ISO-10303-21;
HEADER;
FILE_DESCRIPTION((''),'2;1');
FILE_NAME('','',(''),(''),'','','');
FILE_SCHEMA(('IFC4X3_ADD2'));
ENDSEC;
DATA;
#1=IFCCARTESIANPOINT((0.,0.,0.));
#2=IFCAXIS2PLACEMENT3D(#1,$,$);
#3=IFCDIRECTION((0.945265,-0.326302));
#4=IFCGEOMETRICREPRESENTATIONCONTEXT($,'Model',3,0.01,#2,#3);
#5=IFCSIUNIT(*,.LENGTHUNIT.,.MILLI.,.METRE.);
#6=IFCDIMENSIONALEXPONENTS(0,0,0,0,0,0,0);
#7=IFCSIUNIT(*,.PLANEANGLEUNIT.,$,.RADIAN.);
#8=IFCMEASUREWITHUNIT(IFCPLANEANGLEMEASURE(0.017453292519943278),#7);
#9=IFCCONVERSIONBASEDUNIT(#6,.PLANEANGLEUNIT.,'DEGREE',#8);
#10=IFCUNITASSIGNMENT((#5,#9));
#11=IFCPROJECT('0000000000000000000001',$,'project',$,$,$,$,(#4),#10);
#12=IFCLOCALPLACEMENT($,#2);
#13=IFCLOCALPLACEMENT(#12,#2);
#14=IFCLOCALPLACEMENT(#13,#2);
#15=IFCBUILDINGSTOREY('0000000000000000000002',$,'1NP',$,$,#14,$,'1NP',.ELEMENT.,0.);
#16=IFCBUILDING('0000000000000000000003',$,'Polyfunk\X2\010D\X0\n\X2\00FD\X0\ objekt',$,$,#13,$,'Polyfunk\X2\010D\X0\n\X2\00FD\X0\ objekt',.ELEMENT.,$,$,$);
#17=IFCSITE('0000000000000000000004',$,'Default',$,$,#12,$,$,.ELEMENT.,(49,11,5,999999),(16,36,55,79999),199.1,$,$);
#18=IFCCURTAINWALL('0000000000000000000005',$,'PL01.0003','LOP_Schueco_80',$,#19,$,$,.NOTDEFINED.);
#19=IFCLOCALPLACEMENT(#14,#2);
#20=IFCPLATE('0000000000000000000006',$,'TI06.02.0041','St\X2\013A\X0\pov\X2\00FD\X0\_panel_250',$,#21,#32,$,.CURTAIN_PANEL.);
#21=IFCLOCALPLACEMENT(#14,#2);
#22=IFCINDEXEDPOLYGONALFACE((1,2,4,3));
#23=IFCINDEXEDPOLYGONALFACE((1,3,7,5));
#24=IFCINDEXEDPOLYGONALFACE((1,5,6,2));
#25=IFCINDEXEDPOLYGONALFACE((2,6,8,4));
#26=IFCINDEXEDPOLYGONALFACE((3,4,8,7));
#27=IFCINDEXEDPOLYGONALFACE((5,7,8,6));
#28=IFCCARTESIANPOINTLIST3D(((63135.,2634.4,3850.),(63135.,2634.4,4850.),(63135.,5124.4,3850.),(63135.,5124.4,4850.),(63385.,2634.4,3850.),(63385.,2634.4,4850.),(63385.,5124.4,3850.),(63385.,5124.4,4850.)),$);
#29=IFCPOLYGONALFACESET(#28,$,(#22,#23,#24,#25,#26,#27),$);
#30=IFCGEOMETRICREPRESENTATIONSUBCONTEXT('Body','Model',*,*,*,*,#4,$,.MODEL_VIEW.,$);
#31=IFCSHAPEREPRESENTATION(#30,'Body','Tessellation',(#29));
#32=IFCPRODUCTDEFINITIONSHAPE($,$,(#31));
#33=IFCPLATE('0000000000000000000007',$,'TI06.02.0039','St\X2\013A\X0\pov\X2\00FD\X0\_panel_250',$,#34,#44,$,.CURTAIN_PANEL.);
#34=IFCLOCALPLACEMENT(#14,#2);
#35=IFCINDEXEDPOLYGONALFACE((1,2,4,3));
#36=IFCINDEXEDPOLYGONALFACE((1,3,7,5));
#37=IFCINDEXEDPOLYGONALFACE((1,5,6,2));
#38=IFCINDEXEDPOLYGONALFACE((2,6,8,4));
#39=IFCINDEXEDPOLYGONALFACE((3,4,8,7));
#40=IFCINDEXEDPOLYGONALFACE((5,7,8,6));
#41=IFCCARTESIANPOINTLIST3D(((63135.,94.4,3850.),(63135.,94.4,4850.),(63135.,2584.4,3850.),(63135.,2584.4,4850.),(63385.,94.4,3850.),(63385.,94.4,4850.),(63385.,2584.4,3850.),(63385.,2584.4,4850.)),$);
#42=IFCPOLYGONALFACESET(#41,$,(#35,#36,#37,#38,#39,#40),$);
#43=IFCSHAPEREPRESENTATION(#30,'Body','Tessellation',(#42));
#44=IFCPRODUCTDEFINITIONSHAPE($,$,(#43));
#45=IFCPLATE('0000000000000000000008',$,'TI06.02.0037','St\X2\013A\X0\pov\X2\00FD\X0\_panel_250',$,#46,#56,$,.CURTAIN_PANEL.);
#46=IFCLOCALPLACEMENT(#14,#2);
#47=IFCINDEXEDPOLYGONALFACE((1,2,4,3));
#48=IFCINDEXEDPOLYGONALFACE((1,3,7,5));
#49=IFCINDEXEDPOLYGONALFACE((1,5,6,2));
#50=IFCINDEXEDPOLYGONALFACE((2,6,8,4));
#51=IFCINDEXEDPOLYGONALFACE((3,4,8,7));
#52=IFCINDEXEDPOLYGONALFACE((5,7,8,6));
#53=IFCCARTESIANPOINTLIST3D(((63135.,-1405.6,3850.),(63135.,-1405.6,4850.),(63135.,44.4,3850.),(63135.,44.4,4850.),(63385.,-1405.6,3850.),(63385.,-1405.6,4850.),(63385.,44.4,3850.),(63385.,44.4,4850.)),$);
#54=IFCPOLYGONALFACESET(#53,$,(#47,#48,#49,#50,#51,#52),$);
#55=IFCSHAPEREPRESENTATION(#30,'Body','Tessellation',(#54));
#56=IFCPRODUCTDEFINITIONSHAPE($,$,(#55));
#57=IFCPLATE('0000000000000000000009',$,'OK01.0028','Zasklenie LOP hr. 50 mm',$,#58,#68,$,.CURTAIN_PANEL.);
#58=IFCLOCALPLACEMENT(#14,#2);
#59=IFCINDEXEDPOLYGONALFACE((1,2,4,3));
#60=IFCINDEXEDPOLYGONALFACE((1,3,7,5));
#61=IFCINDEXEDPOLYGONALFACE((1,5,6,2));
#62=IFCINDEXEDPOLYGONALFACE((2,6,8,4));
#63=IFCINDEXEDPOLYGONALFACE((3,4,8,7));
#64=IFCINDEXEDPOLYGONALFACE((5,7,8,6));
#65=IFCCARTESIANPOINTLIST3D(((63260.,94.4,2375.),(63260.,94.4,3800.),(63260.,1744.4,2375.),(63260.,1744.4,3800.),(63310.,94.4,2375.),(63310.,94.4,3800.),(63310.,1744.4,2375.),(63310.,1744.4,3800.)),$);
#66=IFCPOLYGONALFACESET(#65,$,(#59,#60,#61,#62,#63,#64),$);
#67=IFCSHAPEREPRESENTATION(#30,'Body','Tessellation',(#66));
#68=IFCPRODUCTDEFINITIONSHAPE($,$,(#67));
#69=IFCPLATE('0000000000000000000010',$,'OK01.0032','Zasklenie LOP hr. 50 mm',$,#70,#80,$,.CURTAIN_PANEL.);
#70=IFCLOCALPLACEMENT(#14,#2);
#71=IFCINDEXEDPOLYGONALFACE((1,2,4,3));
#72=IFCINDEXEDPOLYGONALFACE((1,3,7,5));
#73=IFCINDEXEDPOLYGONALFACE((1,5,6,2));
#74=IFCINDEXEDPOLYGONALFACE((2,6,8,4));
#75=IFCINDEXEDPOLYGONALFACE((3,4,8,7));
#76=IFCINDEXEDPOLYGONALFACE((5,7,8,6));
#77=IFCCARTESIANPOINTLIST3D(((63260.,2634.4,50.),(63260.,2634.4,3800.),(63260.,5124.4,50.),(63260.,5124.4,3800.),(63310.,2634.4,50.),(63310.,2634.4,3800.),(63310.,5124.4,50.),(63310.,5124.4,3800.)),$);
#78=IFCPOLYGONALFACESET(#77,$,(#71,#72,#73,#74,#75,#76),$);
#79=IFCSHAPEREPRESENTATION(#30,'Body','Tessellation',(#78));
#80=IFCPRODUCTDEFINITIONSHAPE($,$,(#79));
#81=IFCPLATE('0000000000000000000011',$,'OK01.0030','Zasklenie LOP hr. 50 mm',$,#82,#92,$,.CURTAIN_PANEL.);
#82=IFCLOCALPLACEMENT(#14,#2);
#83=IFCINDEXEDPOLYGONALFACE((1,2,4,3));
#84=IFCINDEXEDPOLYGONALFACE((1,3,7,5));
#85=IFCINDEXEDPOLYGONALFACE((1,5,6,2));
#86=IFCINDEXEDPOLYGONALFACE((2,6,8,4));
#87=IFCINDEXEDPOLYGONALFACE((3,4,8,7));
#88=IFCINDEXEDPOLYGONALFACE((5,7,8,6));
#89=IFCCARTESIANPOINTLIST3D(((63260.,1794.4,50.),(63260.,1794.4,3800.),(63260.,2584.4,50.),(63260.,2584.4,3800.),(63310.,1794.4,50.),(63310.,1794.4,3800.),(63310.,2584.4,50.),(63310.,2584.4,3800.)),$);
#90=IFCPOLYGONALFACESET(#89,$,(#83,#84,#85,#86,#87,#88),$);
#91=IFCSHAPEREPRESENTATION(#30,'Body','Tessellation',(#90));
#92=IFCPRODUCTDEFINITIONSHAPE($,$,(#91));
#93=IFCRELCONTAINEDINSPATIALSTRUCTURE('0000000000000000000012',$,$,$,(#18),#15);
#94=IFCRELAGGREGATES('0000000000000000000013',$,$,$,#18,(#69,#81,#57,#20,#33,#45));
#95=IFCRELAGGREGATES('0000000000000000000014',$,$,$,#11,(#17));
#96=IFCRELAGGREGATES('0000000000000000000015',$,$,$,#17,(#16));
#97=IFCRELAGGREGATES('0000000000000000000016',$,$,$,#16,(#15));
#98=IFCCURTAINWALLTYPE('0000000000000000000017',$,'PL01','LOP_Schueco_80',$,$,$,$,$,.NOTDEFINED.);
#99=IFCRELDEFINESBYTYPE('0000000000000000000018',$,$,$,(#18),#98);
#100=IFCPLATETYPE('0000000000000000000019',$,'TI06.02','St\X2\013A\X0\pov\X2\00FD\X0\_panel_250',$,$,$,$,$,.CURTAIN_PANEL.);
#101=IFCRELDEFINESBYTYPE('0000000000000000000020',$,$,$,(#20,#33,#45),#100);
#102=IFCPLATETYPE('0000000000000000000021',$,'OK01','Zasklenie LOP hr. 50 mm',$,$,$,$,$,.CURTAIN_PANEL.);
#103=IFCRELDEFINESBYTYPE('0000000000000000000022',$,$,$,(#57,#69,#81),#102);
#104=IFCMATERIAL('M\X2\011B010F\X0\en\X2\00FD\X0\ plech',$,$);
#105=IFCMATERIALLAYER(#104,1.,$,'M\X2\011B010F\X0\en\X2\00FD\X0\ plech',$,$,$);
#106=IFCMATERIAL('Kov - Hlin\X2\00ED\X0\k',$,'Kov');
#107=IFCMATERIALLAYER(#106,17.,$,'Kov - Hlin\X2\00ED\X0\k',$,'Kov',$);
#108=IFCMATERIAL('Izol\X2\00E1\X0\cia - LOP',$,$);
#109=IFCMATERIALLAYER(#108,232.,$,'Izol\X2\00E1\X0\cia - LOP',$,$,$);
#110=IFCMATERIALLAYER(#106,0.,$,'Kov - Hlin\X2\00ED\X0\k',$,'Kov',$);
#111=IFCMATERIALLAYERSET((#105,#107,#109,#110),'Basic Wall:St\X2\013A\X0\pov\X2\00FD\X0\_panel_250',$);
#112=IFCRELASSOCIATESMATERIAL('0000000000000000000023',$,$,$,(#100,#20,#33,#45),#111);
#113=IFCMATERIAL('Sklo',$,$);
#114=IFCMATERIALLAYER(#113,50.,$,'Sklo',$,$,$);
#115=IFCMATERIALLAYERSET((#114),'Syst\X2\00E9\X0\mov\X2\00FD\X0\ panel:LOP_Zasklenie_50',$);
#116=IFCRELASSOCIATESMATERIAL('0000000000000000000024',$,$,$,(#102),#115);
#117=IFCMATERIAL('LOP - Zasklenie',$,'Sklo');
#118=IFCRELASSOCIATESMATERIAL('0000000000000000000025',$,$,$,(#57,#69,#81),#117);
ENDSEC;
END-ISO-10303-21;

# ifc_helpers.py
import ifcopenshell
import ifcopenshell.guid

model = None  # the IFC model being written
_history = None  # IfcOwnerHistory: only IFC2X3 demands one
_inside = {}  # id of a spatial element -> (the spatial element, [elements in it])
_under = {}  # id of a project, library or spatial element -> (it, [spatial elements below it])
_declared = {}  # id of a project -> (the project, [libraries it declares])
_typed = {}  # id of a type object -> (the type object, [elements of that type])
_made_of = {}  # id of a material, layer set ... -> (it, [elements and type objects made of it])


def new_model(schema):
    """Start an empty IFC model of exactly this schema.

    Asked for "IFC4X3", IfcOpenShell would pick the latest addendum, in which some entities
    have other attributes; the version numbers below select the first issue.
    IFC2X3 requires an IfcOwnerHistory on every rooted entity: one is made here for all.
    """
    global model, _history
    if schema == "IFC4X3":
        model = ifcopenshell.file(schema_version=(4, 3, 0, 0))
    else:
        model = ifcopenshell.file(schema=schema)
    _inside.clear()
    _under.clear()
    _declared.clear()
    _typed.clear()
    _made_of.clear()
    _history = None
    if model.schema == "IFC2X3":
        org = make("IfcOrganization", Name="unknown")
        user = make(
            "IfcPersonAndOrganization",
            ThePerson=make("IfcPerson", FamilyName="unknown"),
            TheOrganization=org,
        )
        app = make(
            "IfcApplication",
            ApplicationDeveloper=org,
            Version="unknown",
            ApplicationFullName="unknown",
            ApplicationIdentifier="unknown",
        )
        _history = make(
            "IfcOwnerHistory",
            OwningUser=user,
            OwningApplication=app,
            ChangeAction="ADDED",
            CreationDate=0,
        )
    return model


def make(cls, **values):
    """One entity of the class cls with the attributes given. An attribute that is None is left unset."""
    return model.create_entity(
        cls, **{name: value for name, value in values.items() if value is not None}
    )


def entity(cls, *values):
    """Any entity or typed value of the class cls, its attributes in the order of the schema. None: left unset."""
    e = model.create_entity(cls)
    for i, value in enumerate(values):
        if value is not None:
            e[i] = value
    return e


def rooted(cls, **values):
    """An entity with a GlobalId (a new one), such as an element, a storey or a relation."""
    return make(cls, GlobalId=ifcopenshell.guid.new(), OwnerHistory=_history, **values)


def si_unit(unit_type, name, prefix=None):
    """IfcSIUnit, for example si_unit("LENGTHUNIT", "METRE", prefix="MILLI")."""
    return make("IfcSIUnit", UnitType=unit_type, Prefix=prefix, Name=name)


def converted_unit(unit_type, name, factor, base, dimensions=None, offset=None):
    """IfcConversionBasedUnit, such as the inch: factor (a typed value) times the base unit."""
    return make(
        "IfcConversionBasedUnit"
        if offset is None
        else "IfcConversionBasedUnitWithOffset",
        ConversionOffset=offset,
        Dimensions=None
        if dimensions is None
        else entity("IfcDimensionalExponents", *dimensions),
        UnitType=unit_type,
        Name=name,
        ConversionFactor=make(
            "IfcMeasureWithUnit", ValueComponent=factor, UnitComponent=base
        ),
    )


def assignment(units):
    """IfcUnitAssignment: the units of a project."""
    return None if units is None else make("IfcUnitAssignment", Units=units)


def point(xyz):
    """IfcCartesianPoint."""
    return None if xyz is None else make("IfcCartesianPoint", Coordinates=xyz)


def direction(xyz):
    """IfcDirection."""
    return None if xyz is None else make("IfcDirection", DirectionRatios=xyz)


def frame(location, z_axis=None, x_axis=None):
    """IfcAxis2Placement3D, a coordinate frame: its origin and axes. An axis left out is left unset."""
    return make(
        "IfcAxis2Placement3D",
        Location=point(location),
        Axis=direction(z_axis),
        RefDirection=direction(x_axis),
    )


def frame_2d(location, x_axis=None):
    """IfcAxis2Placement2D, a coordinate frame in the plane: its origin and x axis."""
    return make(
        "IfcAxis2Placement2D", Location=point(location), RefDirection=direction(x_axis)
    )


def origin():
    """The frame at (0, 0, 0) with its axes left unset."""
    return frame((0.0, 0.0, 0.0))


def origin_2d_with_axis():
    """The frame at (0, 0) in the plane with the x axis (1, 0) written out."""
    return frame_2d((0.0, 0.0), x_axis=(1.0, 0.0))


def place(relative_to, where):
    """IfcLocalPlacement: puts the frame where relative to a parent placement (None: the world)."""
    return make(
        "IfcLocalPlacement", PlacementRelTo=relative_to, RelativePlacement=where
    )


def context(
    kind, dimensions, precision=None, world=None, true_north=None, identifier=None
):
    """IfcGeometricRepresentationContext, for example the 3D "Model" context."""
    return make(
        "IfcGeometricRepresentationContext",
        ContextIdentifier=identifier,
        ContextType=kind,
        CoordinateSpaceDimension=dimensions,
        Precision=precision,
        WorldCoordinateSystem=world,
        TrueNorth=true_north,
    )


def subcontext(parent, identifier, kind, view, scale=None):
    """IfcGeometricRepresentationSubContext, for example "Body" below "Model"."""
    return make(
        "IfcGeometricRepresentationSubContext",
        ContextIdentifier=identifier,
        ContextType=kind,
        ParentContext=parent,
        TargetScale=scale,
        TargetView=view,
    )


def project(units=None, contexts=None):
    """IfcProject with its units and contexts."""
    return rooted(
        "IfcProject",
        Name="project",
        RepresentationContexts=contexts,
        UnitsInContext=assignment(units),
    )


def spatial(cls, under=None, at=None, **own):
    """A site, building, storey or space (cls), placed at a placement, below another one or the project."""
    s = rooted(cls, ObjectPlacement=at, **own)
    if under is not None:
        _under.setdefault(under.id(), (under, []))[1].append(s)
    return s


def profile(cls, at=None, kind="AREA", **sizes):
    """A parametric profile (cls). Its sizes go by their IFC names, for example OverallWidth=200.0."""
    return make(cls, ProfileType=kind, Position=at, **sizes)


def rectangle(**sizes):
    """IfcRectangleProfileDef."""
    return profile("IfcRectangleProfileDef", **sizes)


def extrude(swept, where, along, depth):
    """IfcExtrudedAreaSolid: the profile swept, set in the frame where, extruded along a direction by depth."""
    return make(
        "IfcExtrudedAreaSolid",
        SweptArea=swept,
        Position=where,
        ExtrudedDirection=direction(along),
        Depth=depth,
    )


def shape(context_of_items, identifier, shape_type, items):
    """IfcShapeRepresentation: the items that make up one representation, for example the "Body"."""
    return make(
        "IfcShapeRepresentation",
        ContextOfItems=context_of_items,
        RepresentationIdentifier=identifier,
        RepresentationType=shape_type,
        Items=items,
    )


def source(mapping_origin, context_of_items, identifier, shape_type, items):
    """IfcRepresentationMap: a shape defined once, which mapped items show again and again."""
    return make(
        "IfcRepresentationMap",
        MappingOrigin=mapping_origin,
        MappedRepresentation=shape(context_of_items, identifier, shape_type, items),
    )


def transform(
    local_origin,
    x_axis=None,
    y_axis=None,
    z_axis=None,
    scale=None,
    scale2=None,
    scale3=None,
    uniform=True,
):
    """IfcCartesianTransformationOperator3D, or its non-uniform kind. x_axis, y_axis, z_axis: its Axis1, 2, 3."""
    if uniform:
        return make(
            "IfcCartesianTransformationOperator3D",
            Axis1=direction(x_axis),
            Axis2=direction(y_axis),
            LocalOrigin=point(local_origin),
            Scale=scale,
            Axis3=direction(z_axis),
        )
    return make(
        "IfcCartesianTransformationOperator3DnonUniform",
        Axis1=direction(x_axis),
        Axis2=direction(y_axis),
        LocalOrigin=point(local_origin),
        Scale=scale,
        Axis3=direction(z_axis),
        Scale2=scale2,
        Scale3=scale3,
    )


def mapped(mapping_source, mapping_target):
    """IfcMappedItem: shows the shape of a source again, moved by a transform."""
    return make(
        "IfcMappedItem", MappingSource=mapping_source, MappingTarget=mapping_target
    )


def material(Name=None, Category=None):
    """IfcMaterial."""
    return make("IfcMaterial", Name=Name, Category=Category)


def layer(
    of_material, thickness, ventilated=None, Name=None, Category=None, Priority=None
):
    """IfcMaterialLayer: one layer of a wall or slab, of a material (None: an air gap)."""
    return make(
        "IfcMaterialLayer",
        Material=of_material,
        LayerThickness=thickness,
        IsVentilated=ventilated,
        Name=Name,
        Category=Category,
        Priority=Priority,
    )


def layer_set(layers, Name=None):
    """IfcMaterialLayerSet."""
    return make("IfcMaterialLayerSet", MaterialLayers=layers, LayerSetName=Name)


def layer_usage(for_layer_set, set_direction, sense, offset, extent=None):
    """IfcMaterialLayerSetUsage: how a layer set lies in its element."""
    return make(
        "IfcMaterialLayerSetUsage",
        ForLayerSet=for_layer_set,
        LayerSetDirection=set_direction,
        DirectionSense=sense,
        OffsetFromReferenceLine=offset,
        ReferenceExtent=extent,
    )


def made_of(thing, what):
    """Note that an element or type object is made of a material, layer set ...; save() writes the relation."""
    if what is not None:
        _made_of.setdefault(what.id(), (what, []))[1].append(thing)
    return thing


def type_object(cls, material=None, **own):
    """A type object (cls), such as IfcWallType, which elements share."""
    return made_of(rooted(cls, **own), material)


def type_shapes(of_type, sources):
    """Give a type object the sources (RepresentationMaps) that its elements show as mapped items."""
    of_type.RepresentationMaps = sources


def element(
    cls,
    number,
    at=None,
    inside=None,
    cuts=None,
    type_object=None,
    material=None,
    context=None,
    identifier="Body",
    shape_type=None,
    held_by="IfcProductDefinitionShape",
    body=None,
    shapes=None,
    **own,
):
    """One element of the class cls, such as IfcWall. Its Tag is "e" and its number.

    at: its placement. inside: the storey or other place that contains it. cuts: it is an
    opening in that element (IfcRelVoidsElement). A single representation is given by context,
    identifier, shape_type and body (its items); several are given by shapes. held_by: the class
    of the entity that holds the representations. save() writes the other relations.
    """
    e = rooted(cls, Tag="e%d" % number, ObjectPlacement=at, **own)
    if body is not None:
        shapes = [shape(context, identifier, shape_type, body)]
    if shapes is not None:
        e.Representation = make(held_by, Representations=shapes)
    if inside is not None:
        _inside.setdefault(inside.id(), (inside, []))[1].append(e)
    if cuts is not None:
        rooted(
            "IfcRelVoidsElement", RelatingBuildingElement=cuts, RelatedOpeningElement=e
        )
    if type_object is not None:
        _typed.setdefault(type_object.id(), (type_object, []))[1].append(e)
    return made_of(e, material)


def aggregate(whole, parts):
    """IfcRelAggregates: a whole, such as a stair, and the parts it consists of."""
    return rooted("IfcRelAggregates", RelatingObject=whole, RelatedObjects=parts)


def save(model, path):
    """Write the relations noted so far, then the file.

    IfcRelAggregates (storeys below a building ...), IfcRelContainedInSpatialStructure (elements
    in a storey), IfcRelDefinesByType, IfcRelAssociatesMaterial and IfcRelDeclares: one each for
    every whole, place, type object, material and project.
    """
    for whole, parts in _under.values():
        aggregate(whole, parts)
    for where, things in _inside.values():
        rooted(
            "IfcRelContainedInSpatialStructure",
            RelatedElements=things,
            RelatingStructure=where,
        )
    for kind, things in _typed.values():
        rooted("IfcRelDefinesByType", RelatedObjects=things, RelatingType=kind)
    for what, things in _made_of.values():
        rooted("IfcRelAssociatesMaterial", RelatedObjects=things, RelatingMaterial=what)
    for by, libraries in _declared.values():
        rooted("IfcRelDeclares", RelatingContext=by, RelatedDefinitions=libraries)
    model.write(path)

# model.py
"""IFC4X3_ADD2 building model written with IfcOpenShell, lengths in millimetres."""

from ifc_helpers import new_model, entity, si_unit, converted_unit, direction, frame, frame_2d, origin, origin_2d_with_axis, place, context, subcontext, project, spatial, rectangle, extrude, source, transform, mapped, material, layer, layer_set, layer_usage, type_object, type_shapes, element, aggregate, save


model = new_model("IFC4X3_ADD2")

# Units and contexts
model_context = context("Model", 3, precision=0.01, world=origin(), true_north=direction((0.945265, -0.326302)))
body_context = subcontext(model_context, "Body", "Model", "MODEL_VIEW")
ifc_project = project(units=[si_unit("LENGTHUNIT", "METRE", prefix="MILLI"), converted_unit("PLANEANGLEUNIT", "DEGREE", entity("IfcPlaneAngleMeasure", 0.017453292519943278), si_unit("PLANEANGLEUNIT", "RADIAN"), dimensions=[0, 0, 0, 0, 0, 0, 0])], contexts=[model_context])

# Site, building, storey
site_placement = place(None, origin())
site = spatial("IfcSite", under=ifc_project, at=site_placement, Name="Default", CompositionType="ELEMENT", RefLatitude=(49, 11, 5, 999999), RefLongitude=(16, 36, 55, 79999), RefElevation=199.1)
building_placement = place(site_placement, origin())
building = spatial("IfcBuilding", under=site, at=building_placement, Name="Polyfunkčný objekt", LongName="Polyfunkčný objekt", CompositionType="ELEMENT")
storey_placement = place(building_placement, origin())
storey = spatial("IfcBuildingStorey", under=building, at=storey_placement, Name="1NP", LongName="1NP", CompositionType="ELEMENT", Elevation=0.0)

# Curtain wall, plates
curtain_wall_type = type_object("IfcCurtainWallType", Name="PL01", Description="LOP_Schueco_80", PredefinedType="NOTDEFINED")
curtain_wall_placement = place(storey_placement, origin())
curtain_wall = element("IfcCurtainWall", 1, at=curtain_wall_placement, inside=storey, type_object=curtain_wall_type, Name="PL01.0003", Description="LOP_Schueco_80", PredefinedType="NOTDEFINED")
ifc_material_1 = material(Name="Měďený plech")
ifc_layer_1 = layer(ifc_material_1, 1.0, Name="Měďený plech")
ifc_material_2 = material(Name="Kov - Hliník", Category="Kov")
ifc_layer_2 = layer(ifc_material_2, 17.0, Name="Kov - Hliník", Category="Kov")
ifc_material_3 = material(Name="Izolácia - LOP")
ifc_layer_3 = layer(ifc_material_3, 232.0, Name="Izolácia - LOP")
ifc_layer_4 = layer(ifc_material_2, 0.0, Name="Kov - Hliník", Category="Kov")
ifc_layer_set_1 = layer_set([ifc_layer_1, ifc_layer_2, ifc_layer_3, ifc_layer_4], Name="Basic Wall:Stĺpový_panel_250")
ifc_layer_usage_1 = layer_usage(ifc_layer_set_1, "AXIS2", "NEGATIVE", 125.0)
plate_type_1 = type_object("IfcPlateType", Name="TI06.02", Description="Stĺpový_panel_250", PredefinedType="CURTAIN_PANEL", material=ifc_layer_set_1)
plate_1_placement = place(storey_placement, frame((63260.0, 5124.4, 3850.0), z_axis=(0.0, 0.0, 1.0), x_axis=(0.0, -1.0, 0.0)))
plate_1 = element("IfcPlate", 2, at=plate_1_placement, type_object=plate_type_1, material=ifc_layer_usage_1, Name="TI06.02.0041", Description="Stĺpový_panel_250", PredefinedType="CURTAIN_PANEL", context=body_context, shape_type="SweptSolid", body=[
    extrude(rectangle(XDim=250.0, YDim=2490.0, at=frame_2d((0.0, 0.0), x_axis=(1.0, 0.0))), frame((1245.0, 0.0, 0.0), z_axis=(0.0, 0.0, 1.0), x_axis=(0.0, 1.0, 0.0)), (0.0, 0.0, 1.0), 1000.0),
])
ifc_layer_usage_2 = layer_usage(ifc_layer_set_1, "AXIS2", "NEGATIVE", 125.0)
plate_2_placement = place(storey_placement, frame((63260.0, 2584.4, 3850.0), z_axis=(0.0, 0.0, 1.0), x_axis=(0.0, -1.0, 0.0)))
plate_2 = element("IfcPlate", 3, at=plate_2_placement, type_object=plate_type_1, material=ifc_layer_usage_2, Name="TI06.02.0039", Description="Stĺpový_panel_250", PredefinedType="CURTAIN_PANEL", context=body_context, shape_type="SweptSolid", body=[
    extrude(rectangle(XDim=250.0, YDim=2490.0, at=frame_2d((0.0, 0.0), x_axis=(1.0, 0.0))), frame((1245.0, 0.0, 0.0), z_axis=(0.0, 0.0, 1.0), x_axis=(0.0, 1.0, 0.0)), (0.0, 0.0, 1.0), 1000.0),
])
ifc_layer_usage_3 = layer_usage(ifc_layer_set_1, "AXIS2", "NEGATIVE", 125.0)
plate_3_placement = place(storey_placement, frame((63260.0, 44.4, 3850.0), z_axis=(0.0, 0.0, 1.0), x_axis=(0.0, -1.0, 0.0)))
plate_3 = element("IfcPlate", 4, at=plate_3_placement, type_object=plate_type_1, material=ifc_layer_usage_3, Name="TI06.02.0037", Description="Stĺpový_panel_250", PredefinedType="CURTAIN_PANEL", context=body_context, shape_type="SweptSolid", body=[
    extrude(rectangle(XDim=250.0, YDim=1450.0, at=frame_2d((0.0, 0.0), x_axis=(1.0, 0.0))), frame((725.0, 0.0, 0.0), z_axis=(0.0, 0.0, 1.0), x_axis=(0.0, 1.0, 0.0)), (0.0, 0.0, 1.0), 1000.0),
])
ifc_material_4 = material(Name="LOP - Zasklenie", Category="Sklo")
ifc_material_5 = material(Name="Sklo")
ifc_layer_5 = layer(ifc_material_5, 50.0, Name="Sklo")
ifc_layer_set_2 = layer_set([ifc_layer_5], Name="Systémový panel:LOP_Zasklenie_50")
plate_type_2 = type_object("IfcPlateType", Name="OK01", Description="Zasklenie LOP hr. 50 mm", PredefinedType="CURTAIN_PANEL", material=ifc_layer_set_2)
shared_shape_1 = source(origin(), body_context, "Body", "SweptSolid", [
    extrude(rectangle(XDim=50.0, YDim=1650.0, at=origin_2d_with_axis()), frame((0.0, 25.0, 0.0), z_axis=(0.0, 0.0, 1.0), x_axis=(0.0, 1.0, 0.0)), (0.0, 0.0, 1.0), 1425.0),
])
plate_4_placement = place(curtain_wall_placement, frame((63260.0, 919.4, 2375.0), z_axis=(0.0, 0.0, 1.0), x_axis=(0.0, -1.0, 0.0)))
plate_4 = element("IfcPlate", 5, at=plate_4_placement, type_object=plate_type_2, material=ifc_material_4, Name="OK01.0028", Description="Zasklenie LOP hr. 50 mm", PredefinedType="CURTAIN_PANEL", context=body_context, shape_type="MappedRepresentation", body=[
    mapped(shared_shape_1, transform((0.0, 0.0, 0.0), scale=1.0)),
])
shared_shape_2 = source(origin(), body_context, "Body", "SweptSolid", [
    extrude(rectangle(XDim=3750.0, YDim=2490.0, at=frame_2d((-141.7, 0.0), x_axis=(1.0, 0.0))), frame((0.0, 0.0, 2016.7), z_axis=(0.0, 1.0, 0.0), x_axis=(0.0, 0.0, 1.0)), (0.0, 0.0, 1.0), 50.0),
])
plate_5_placement = place(curtain_wall_placement, frame((63260.0, 3879.4, 50.0), z_axis=(0.0, 0.0, 1.0), x_axis=(0.0, -1.0, 0.0)))
plate_5 = element("IfcPlate", 6, at=plate_5_placement, type_object=plate_type_2, material=ifc_material_4, Name="OK01.0032", Description="Zasklenie LOP hr. 50 mm", PredefinedType="CURTAIN_PANEL", context=body_context, shape_type="MappedRepresentation", body=[
    mapped(shared_shape_2, transform((0.0, 0.0, 0.0), scale=1.0)),
])
shared_shape_3 = source(origin(), body_context, "Body", "SweptSolid", [
    extrude(rectangle(XDim=3750.0, YDim=790.0, at=frame_2d((-141.7, 0.0), x_axis=(1.0, 0.0))), frame((0.0, 0.0, 2016.7), z_axis=(0.0, 1.0, 0.0), x_axis=(0.0, 0.0, 1.0)), (0.0, 0.0, 1.0), 50.0),
])
type_shapes(plate_type_2, [shared_shape_1, shared_shape_2, shared_shape_3])
plate_6_placement = place(curtain_wall_placement, frame((63260.0, 2189.4, 50.0), z_axis=(0.0, 0.0, 1.0), x_axis=(0.0, -1.0, 0.0)))
plate_6 = element("IfcPlate", 7, at=plate_6_placement, type_object=plate_type_2, material=ifc_material_4, Name="OK01.0030", Description="Zasklenie LOP hr. 50 mm", PredefinedType="CURTAIN_PANEL", context=body_context, shape_type="MappedRepresentation", body=[
    mapped(shared_shape_3, transform((0.0, 0.0, 0.0), scale=1.0)),
])
aggregate(curtain_wall, [plate_5, plate_6, plate_4, plate_1, plate_2, plate_3])

save(model, "model.ifc")
